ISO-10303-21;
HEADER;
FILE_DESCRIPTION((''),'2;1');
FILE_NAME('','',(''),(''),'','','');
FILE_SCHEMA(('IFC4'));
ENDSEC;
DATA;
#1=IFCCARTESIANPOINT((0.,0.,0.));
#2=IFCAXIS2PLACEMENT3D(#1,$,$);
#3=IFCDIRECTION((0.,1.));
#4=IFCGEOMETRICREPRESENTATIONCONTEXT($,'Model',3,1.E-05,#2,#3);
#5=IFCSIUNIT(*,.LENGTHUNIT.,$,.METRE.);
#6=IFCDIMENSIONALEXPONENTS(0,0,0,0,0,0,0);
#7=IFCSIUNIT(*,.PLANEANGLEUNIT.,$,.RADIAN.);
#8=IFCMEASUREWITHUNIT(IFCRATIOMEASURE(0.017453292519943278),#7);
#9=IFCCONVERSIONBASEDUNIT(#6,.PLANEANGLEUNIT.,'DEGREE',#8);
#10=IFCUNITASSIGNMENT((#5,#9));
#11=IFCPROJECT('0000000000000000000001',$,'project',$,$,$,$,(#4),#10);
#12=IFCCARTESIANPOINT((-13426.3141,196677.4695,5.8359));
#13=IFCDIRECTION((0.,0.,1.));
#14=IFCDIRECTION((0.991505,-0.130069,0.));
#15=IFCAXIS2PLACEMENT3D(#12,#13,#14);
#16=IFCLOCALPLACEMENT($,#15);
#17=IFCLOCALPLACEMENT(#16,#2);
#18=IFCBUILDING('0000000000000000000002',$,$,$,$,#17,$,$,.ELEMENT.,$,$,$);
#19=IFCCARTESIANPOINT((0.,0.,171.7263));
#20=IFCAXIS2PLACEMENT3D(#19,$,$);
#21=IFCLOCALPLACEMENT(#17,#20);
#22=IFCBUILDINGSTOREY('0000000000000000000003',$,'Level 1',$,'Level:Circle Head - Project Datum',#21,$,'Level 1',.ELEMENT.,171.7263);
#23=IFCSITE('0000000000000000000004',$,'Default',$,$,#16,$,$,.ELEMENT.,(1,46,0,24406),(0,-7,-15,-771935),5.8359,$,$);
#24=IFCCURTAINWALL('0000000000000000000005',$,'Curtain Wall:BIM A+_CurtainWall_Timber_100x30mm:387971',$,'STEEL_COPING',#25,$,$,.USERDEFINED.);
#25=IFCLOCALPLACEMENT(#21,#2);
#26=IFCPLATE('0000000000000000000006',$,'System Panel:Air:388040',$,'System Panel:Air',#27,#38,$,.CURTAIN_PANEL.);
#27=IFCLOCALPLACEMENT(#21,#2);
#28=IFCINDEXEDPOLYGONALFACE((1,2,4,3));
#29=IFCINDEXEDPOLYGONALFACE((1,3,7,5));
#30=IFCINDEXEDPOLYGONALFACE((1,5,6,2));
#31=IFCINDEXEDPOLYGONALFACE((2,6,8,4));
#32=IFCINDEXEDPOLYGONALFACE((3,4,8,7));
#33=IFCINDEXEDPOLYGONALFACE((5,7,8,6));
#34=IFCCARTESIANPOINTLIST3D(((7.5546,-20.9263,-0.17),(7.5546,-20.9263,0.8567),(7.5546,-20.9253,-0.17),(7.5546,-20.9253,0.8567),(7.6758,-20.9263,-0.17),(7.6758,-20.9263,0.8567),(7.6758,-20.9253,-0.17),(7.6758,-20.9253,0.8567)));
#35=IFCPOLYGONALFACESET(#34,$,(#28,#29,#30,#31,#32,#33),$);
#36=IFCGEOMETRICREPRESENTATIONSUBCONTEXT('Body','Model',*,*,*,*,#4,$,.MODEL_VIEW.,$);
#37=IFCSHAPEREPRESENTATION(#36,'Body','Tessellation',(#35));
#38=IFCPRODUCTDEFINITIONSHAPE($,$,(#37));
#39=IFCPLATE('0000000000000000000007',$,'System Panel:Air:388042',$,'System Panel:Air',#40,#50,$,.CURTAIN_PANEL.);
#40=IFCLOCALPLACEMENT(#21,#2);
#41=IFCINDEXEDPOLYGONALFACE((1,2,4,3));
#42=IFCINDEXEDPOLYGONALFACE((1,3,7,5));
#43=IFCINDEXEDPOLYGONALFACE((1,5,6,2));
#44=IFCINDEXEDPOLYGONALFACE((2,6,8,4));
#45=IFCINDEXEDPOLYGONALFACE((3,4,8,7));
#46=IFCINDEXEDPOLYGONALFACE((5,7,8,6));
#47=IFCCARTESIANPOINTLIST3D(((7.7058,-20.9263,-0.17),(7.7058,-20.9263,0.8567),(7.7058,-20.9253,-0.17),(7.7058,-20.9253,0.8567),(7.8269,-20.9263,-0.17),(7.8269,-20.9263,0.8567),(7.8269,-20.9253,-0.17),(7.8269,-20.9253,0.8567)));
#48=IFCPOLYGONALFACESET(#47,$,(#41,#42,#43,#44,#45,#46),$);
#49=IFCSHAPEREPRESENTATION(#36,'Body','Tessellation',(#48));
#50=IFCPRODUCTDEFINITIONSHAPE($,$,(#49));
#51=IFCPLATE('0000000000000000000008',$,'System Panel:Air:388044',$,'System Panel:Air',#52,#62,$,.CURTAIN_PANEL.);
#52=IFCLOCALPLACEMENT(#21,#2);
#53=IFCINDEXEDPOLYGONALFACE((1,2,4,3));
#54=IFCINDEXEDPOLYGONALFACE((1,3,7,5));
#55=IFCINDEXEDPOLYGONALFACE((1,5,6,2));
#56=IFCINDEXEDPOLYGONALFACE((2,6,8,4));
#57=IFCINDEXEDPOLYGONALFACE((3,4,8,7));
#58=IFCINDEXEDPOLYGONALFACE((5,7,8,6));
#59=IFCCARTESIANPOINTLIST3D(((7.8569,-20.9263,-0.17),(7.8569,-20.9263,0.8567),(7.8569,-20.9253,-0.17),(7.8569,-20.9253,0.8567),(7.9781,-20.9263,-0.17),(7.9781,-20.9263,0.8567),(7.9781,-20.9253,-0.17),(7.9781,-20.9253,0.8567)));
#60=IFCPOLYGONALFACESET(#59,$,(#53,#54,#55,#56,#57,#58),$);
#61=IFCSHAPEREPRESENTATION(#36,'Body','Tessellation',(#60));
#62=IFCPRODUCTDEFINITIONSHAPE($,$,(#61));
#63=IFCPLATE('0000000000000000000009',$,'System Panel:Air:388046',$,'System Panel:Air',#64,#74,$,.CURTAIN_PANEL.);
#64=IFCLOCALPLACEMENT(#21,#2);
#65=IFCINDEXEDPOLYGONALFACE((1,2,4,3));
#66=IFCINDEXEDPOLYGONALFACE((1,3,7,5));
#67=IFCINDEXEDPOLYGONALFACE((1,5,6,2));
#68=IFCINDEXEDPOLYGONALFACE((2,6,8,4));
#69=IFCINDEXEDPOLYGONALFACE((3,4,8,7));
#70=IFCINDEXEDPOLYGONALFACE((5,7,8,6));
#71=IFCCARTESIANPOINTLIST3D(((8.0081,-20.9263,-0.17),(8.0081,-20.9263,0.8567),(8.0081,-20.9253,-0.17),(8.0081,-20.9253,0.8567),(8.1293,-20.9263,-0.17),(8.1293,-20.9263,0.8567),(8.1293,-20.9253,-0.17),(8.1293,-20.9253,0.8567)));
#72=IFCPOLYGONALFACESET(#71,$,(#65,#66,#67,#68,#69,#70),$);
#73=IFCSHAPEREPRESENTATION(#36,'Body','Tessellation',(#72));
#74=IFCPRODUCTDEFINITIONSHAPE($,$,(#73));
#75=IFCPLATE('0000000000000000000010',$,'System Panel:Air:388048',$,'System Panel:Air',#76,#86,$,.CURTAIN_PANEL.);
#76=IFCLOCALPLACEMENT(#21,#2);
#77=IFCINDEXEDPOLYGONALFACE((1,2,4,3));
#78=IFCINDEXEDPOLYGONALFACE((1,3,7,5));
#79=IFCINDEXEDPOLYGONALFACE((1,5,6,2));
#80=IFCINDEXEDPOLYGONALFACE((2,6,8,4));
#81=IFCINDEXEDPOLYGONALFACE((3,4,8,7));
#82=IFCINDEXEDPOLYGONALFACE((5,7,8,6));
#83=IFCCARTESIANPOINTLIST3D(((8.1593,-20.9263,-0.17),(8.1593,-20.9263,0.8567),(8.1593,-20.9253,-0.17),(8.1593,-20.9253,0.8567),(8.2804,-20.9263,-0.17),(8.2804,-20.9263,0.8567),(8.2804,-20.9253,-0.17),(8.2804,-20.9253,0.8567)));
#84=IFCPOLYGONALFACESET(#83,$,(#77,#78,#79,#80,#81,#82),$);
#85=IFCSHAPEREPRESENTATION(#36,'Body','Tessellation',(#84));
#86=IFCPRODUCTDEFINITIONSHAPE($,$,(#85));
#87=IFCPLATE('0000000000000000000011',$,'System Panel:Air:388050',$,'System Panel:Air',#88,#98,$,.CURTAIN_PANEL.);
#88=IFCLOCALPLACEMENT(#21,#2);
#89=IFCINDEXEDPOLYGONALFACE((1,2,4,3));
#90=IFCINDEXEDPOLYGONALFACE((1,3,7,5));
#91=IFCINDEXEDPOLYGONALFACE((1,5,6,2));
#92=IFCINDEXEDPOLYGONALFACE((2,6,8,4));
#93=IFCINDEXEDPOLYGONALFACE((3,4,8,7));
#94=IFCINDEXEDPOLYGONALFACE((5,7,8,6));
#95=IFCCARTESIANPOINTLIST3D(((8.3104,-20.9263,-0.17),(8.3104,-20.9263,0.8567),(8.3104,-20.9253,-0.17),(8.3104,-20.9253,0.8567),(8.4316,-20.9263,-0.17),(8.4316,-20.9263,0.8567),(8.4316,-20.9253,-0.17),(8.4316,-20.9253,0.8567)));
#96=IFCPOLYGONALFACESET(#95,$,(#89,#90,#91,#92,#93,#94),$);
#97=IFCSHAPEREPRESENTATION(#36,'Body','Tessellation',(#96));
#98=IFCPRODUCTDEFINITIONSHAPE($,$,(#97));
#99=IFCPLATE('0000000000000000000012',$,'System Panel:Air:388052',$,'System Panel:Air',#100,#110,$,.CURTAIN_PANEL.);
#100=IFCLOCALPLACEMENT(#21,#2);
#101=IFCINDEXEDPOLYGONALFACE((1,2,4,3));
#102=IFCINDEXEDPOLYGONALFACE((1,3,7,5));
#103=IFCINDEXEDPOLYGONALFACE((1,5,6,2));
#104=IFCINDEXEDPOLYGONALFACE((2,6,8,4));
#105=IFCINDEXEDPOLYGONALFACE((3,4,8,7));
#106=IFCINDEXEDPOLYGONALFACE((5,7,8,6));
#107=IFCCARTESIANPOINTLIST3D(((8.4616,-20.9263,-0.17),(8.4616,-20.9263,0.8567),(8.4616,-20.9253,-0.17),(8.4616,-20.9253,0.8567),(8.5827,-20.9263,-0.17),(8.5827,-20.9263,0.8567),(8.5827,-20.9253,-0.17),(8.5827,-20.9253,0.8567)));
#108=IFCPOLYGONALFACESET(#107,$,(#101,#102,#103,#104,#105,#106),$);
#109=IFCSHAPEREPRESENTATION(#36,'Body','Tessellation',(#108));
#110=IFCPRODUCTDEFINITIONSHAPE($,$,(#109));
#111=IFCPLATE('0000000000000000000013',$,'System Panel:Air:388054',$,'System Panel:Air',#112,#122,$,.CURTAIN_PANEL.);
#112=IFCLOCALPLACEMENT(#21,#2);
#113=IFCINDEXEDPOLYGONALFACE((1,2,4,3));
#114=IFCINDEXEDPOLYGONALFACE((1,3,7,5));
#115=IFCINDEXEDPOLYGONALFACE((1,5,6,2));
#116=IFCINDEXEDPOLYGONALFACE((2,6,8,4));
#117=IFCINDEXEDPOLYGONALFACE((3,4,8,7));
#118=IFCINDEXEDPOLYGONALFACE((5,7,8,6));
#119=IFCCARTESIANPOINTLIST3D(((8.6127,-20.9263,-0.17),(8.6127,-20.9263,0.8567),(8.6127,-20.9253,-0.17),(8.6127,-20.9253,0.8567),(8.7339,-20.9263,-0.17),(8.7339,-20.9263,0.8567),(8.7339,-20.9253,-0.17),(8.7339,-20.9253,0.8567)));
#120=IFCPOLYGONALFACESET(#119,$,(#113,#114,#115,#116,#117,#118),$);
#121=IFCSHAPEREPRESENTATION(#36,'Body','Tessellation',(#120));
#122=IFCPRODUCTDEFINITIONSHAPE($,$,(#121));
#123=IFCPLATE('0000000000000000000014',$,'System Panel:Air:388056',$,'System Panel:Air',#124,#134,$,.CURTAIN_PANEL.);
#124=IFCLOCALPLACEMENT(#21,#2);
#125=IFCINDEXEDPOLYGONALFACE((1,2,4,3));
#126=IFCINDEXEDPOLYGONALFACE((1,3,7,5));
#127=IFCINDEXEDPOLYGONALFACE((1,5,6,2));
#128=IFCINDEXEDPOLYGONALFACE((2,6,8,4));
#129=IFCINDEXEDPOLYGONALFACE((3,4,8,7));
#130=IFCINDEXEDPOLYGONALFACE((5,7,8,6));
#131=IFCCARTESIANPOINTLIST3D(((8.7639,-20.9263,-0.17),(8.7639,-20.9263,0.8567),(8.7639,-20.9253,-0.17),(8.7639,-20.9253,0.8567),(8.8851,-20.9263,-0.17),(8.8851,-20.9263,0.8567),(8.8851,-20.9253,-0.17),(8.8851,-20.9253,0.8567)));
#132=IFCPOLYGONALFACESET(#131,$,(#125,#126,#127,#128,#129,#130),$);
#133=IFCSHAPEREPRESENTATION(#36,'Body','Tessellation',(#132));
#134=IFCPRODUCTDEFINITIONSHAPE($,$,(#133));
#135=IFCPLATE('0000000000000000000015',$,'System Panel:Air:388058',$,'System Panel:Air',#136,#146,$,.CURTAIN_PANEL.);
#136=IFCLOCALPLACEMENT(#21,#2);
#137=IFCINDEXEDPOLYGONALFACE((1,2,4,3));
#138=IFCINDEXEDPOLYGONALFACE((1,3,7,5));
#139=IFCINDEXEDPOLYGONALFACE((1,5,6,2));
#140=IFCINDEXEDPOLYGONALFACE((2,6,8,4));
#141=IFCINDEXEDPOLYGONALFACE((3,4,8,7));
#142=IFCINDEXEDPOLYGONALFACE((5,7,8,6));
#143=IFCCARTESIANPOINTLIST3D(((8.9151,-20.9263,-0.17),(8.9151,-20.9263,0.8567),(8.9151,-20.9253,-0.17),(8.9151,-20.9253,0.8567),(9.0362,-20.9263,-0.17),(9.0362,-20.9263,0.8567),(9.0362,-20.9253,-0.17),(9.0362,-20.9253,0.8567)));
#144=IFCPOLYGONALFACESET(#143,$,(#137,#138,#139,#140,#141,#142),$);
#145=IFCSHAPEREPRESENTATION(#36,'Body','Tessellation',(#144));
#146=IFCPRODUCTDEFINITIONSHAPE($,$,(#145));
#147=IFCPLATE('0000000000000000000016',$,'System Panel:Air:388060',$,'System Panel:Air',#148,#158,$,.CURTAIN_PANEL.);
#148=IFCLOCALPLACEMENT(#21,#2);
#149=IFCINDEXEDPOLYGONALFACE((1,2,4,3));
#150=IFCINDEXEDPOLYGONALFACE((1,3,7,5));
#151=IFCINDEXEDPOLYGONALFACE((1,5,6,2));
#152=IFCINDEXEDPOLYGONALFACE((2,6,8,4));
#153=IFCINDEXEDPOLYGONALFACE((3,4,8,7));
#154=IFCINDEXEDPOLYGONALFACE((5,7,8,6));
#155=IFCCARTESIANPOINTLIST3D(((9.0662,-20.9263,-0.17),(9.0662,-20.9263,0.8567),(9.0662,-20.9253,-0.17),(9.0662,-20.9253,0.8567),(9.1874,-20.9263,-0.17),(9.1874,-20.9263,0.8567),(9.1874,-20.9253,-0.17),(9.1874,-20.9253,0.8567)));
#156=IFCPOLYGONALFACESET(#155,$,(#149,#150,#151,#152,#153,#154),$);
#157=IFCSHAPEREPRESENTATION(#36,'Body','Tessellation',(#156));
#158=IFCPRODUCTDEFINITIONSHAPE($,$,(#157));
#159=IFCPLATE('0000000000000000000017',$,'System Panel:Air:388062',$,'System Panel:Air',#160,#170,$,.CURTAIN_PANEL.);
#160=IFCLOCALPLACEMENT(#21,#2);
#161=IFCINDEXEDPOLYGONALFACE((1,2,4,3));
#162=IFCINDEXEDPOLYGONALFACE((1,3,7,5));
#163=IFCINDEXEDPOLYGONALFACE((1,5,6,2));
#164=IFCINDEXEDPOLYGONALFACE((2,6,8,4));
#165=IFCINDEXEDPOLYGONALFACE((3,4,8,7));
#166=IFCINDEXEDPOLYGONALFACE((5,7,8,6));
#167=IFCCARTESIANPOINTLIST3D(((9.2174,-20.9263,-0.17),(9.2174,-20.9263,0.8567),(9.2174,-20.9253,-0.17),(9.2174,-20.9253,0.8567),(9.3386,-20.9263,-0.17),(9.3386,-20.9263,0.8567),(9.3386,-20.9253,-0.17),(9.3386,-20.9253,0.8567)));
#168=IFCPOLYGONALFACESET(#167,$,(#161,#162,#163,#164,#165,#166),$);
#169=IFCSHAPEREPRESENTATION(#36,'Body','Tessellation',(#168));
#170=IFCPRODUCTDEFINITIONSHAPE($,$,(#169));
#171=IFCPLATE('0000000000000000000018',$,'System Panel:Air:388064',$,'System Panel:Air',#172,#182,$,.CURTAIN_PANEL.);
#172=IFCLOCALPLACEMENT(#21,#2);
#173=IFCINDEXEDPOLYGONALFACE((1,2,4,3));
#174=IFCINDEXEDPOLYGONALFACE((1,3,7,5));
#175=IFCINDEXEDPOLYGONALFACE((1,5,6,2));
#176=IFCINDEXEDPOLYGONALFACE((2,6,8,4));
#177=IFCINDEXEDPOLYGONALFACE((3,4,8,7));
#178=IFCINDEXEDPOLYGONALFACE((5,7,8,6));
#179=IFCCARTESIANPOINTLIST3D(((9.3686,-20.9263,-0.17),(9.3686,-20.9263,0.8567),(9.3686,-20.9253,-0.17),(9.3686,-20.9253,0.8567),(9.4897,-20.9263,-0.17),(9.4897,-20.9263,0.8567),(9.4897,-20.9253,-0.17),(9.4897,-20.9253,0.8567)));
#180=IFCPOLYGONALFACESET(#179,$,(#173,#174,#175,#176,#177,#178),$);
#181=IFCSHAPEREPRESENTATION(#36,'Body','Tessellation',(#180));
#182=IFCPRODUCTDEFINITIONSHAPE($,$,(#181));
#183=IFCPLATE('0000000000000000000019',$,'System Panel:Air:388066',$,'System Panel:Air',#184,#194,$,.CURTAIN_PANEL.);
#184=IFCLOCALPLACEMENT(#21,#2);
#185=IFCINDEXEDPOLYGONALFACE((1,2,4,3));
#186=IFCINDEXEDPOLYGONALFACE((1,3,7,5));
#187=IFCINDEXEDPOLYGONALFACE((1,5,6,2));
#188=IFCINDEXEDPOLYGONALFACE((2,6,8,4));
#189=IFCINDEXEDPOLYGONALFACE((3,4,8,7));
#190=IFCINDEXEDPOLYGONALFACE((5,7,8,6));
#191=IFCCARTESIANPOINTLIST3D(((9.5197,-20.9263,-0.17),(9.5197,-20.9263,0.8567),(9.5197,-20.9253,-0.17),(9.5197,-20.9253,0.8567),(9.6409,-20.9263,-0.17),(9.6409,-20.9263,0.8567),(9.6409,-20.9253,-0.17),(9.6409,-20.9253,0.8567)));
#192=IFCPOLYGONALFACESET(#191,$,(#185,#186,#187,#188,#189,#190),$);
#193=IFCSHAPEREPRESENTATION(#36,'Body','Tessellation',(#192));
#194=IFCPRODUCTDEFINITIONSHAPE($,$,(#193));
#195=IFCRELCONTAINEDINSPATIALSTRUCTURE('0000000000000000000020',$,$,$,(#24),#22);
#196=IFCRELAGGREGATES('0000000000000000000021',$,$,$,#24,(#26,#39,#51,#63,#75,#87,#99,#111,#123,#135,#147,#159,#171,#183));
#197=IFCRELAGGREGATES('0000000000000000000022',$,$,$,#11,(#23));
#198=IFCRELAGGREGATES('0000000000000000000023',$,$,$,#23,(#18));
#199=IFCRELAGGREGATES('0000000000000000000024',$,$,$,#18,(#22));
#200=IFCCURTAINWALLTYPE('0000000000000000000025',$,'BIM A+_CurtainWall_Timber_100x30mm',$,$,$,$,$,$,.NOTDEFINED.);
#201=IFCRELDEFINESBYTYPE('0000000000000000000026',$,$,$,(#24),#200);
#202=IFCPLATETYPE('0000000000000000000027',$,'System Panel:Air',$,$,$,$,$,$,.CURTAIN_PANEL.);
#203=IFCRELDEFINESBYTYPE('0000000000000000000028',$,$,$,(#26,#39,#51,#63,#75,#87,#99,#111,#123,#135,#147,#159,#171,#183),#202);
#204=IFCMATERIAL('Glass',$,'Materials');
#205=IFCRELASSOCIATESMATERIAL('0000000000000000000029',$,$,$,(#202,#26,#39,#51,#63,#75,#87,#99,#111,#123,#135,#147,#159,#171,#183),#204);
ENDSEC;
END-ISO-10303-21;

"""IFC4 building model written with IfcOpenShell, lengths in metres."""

from ifc_helpers import new_model, entity, si_unit, converted_unit, direction, frame, origin, place, context, subcontext, project, spatial, indexed_curve, outline, extrude, source, transform, mapped, material, type_object, type_shapes, element, aggregate, save


model = new_model("IFC4")

# Units and contexts
model_context = context("Model", 3, precision=1e-05, world=origin(), true_north=direction((0.0, 1.0)))
body_context = subcontext(model_context, "Body", "Model", "MODEL_VIEW")
ifc_project = project(units=[si_unit("LENGTHUNIT", "METRE"), converted_unit("PLANEANGLEUNIT", "DEGREE", entity("IfcRatioMeasure", 0.017453292519943278), si_unit("PLANEANGLEUNIT", "RADIAN"), dimensions=[0, 0, 0, 0, 0, 0, 0])], contexts=[model_context])

# Site, building, storey
site_placement = place(None, frame((-13426.3141, 196677.4695, 5.8359), z_axis=(0.0, 0.0, 1.0), x_axis=(0.991505, -0.130069, 0.0)))
site = spatial("IfcSite", under=ifc_project, at=site_placement, Name="Default", CompositionType="ELEMENT", RefLatitude=(1, 46, 0, 24406), RefLongitude=(0, -7, -15, -771935), RefElevation=5.8359)
building_placement = place(site_placement, origin())
building = spatial("IfcBuilding", under=site, at=building_placement, CompositionType="ELEMENT")
storey_placement = place(building_placement, frame((0.0, 0.0, 171.7263)))
storey = spatial("IfcBuildingStorey", under=building, at=storey_placement, Name="Level 1", ObjectType="Level:Circle Head - Project Datum", LongName="Level 1", CompositionType="ELEMENT", Elevation=171.7263)

# Shared definitions
ifc_material_1 = material(Name="Glass", Category="Materials")

# Curtain wall, plates
curtain_wall_type_1 = type_object("IfcCurtainWallType", Name="BIM A+_CurtainWall_Timber_100x30mm", PredefinedType="NOTDEFINED")
curtain_wall_1_placement = place(storey_placement, frame((0.0, 0.0, -171.7263)))
curtain_wall_1 = element("IfcCurtainWall", 1, at=curtain_wall_1_placement, inside=storey, type_object=curtain_wall_type_1, Name="Curtain Wall:BIM A+_CurtainWall_Timber_100x30mm:387971", ObjectType="STEEL_COPING", PredefinedType="USERDEFINED")
plate_type_1 = type_object("IfcPlateType", Name="System Panel:Air", PredefinedType="CURTAIN_PANEL", material=ifc_material_1)
shared_shape_1 = source(origin(), body_context, "Body", "SweptSolid", [
    extrude(outline(indexed_curve([(-0.0005, -0.0606), (0.0005, -0.0606), (0.0005, 0.0606), (-0.0005, 0.0606), (-0.0005, -0.0606)], self_intersect=False)), frame((0.0, 0.0, 0.0), z_axis=(0.0, 0.0, 1.0), x_axis=(0.0, 1.0, 0.0)), (0.0, 0.0, 1.0), 1.0267),
])
type_shapes(plate_type_1, [shared_shape_1])
plate_1_placement = place(curtain_wall_1_placement, frame((7.6152, -20.9258, 171.5563)))
plate_1 = element("IfcPlate", 2, at=plate_1_placement, type_object=plate_type_1, material=ifc_material_1, Name="System Panel:Air:388040", ObjectType="System Panel:Air", PredefinedType="CURTAIN_PANEL", context=body_context, shape_type="MappedRepresentation", body=[
    mapped(shared_shape_1, transform((0.0, 0.0, 0.0), scale=1.0)),
])
plate_2_placement = place(curtain_wall_1_placement, frame((7.7664, -20.9258, 171.5563)))
plate_2 = element("IfcPlate", 3, at=plate_2_placement, type_object=plate_type_1, material=ifc_material_1, Name="System Panel:Air:388042", ObjectType="System Panel:Air", PredefinedType="CURTAIN_PANEL", context=body_context, shape_type="MappedRepresentation", body=[
    mapped(shared_shape_1, transform((0.0, 0.0, 0.0), scale=1.0)),
])
plate_3_placement = place(curtain_wall_1_placement, frame((7.9175, -20.9258, 171.5563)))
plate_3 = element("IfcPlate", 4, at=plate_3_placement, type_object=plate_type_1, material=ifc_material_1, Name="System Panel:Air:388044", ObjectType="System Panel:Air", PredefinedType="CURTAIN_PANEL", context=body_context, shape_type="MappedRepresentation", body=[
    mapped(shared_shape_1, transform((0.0, 0.0, 0.0), scale=1.0)),
])
plate_4_placement = place(curtain_wall_1_placement, frame((8.0687, -20.9258, 171.5563)))
plate_4 = element("IfcPlate", 5, at=plate_4_placement, type_object=plate_type_1, material=ifc_material_1, Name="System Panel:Air:388046", ObjectType="System Panel:Air", PredefinedType="CURTAIN_PANEL", context=body_context, shape_type="MappedRepresentation", body=[
    mapped(shared_shape_1, transform((0.0, 0.0, 0.0), scale=1.0)),
])
plate_5_placement = place(curtain_wall_1_placement, frame((8.2198, -20.9258, 171.5563)))
plate_5 = element("IfcPlate", 6, at=plate_5_placement, type_object=plate_type_1, material=ifc_material_1, Name="System Panel:Air:388048", ObjectType="System Panel:Air", PredefinedType="CURTAIN_PANEL", context=body_context, shape_type="MappedRepresentation", body=[
    mapped(shared_shape_1, transform((0.0, 0.0, 0.0), scale=1.0)),
])
plate_6_placement = place(curtain_wall_1_placement, frame((8.371, -20.9258, 171.5563)))
plate_6 = element("IfcPlate", 7, at=plate_6_placement, type_object=plate_type_1, material=ifc_material_1, Name="System Panel:Air:388050", ObjectType="System Panel:Air", PredefinedType="CURTAIN_PANEL", context=body_context, shape_type="MappedRepresentation", body=[
    mapped(shared_shape_1, transform((0.0, 0.0, 0.0), scale=1.0)),
])
plate_7_placement = place(curtain_wall_1_placement, frame((8.5222, -20.9258, 171.5563)))
plate_7 = element("IfcPlate", 8, at=plate_7_placement, type_object=plate_type_1, material=ifc_material_1, Name="System Panel:Air:388052", ObjectType="System Panel:Air", PredefinedType="CURTAIN_PANEL", context=body_context, shape_type="MappedRepresentation", body=[
    mapped(shared_shape_1, transform((0.0, 0.0, 0.0), scale=1.0)),
])
plate_8_placement = place(curtain_wall_1_placement, frame((8.6733, -20.9258, 171.5563)))
plate_8 = element("IfcPlate", 9, at=plate_8_placement, type_object=plate_type_1, material=ifc_material_1, Name="System Panel:Air:388054", ObjectType="System Panel:Air", PredefinedType="CURTAIN_PANEL", context=body_context, shape_type="MappedRepresentation", body=[
    mapped(shared_shape_1, transform((0.0, 0.0, 0.0), scale=1.0)),
])
plate_9_placement = place(curtain_wall_1_placement, frame((8.8245, -20.9258, 171.5563)))
plate_9 = element("IfcPlate", 10, at=plate_9_placement, type_object=plate_type_1, material=ifc_material_1, Name="System Panel:Air:388056", ObjectType="System Panel:Air", PredefinedType="CURTAIN_PANEL", context=body_context, shape_type="MappedRepresentation", body=[
    mapped(shared_shape_1, transform((0.0, 0.0, 0.0), scale=1.0)),
])
plate_10_placement = place(curtain_wall_1_placement, frame((8.9757, -20.9258, 171.5563)))
plate_10 = element("IfcPlate", 11, at=plate_10_placement, type_object=plate_type_1, material=ifc_material_1, Name="System Panel:Air:388058", ObjectType="System Panel:Air", PredefinedType="CURTAIN_PANEL", context=body_context, shape_type="MappedRepresentation", body=[
    mapped(shared_shape_1, transform((0.0, 0.0, 0.0), scale=1.0)),
])
plate_11_placement = place(curtain_wall_1_placement, frame((9.1268, -20.9258, 171.5563)))
plate_11 = element("IfcPlate", 12, at=plate_11_placement, type_object=plate_type_1, material=ifc_material_1, Name="System Panel:Air:388060", ObjectType="System Panel:Air", PredefinedType="CURTAIN_PANEL", context=body_context, shape_type="MappedRepresentation", body=[
    mapped(shared_shape_1, transform((0.0, 0.0, 0.0), scale=1.0)),
])
plate_12_placement = place(curtain_wall_1_placement, frame((9.278, -20.9258, 171.5563)))
plate_12 = element("IfcPlate", 13, at=plate_12_placement, type_object=plate_type_1, material=ifc_material_1, Name="System Panel:Air:388062", ObjectType="System Panel:Air", PredefinedType="CURTAIN_PANEL", context=body_context, shape_type="MappedRepresentation", body=[
    mapped(shared_shape_1, transform((0.0, 0.0, 0.0), scale=1.0)),
])
plate_13_placement = place(curtain_wall_1_placement, frame((9.4291, -20.9258, 171.5563)))
plate_13 = element("IfcPlate", 14, at=plate_13_placement, type_object=plate_type_1, material=ifc_material_1, Name="System Panel:Air:388064", ObjectType="System Panel:Air", PredefinedType="CURTAIN_PANEL", context=body_context, shape_type="MappedRepresentation", body=[
    mapped(shared_shape_1, transform((0.0, 0.0, 0.0), scale=1.0)),
])
plate_14_placement = place(curtain_wall_1_placement, frame((9.5803, -20.9258, 171.5563)))
plate_14 = element("IfcPlate", 15, at=plate_14_placement, type_object=plate_type_1, material=ifc_material_1, Name="System Panel:Air:388066", ObjectType="System Panel:Air", PredefinedType="CURTAIN_PANEL", context=body_context, shape_type="MappedRepresentation", body=[
    mapped(shared_shape_1, transform((0.0, 0.0, 0.0), scale=1.0)),
])
aggregate(curtain_wall_1, [plate_1, plate_2, plate_3, plate_4, plate_5, plate_6, plate_7, plate_8, plate_9, plate_10, plate_11, plate_12, plate_13, plate_14])

save(model, "model.ifc")
